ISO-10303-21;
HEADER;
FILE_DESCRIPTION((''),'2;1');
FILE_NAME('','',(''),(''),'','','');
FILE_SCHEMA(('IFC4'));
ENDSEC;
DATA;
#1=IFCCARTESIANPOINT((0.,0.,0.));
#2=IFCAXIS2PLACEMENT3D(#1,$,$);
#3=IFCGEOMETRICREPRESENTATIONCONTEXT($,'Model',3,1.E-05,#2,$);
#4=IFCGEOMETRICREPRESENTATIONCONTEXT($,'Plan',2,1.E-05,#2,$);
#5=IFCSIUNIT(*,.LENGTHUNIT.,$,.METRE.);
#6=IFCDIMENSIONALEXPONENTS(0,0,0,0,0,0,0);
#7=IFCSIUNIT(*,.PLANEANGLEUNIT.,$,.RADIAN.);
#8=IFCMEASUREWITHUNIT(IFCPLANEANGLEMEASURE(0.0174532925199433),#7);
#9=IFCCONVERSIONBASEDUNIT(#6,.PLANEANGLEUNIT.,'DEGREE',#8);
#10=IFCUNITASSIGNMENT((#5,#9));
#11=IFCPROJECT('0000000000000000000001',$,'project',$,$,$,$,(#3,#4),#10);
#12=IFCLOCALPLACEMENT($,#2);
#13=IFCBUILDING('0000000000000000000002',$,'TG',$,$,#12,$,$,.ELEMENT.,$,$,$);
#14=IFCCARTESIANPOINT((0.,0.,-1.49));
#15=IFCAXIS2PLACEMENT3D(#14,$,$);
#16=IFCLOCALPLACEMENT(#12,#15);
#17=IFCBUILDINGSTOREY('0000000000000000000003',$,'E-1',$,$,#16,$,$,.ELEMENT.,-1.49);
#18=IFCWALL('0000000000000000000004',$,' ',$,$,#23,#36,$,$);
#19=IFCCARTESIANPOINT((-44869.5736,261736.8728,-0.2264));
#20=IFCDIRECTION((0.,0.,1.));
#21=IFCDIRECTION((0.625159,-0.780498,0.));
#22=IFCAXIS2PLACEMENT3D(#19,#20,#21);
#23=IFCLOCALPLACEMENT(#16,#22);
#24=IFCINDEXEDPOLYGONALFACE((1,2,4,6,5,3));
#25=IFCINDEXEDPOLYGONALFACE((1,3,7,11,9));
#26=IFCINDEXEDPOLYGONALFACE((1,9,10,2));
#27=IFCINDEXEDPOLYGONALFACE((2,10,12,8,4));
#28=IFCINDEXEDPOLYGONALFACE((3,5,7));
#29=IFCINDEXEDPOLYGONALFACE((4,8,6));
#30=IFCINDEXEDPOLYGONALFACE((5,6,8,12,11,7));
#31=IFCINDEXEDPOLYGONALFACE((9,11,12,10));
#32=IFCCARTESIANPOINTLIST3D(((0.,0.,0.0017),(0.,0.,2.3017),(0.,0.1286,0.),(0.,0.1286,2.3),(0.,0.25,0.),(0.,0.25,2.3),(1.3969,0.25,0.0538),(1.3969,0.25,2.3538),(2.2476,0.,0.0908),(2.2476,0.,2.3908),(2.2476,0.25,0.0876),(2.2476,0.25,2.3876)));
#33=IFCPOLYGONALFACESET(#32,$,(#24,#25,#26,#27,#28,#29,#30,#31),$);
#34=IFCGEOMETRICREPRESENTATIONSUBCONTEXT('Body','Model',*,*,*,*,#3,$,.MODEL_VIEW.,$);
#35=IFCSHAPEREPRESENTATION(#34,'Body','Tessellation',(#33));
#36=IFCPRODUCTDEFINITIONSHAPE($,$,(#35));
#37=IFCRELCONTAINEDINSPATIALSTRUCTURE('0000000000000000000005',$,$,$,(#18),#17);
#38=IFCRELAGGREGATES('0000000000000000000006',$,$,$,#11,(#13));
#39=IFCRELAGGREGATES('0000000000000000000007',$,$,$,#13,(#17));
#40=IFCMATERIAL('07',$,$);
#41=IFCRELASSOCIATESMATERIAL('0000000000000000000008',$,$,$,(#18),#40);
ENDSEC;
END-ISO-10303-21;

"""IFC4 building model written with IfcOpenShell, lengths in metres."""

from ifc_helpers import new_model, entity, si_unit, converted_unit, frame, frame_2d, origin, origin_with_axes, place, context, subcontext, project, spatial, polyline, rectangle, extrude, clip, bounded_halfspace, material, element, save


model = new_model("IFC4")

# Units and contexts
model_context = context("Model", 3, precision=1e-05, world=origin())
plan_context = context("Plan", 2, precision=1e-05, world=origin())
body_context = subcontext(model_context, "Body", "Model", "MODEL_VIEW")
ifc_project = project(units=[si_unit("LENGTHUNIT", "METRE"), converted_unit("PLANEANGLEUNIT", "DEGREE", entity("IfcPlaneAngleMeasure", 0.0174532925199433), si_unit("PLANEANGLEUNIT", "RADIAN"), dimensions=[0, 0, 0, 0, 0, 0, 0])], contexts=[model_context, plan_context])

# Building, storey
building_placement = place(None, origin())
building = spatial("IfcBuilding", under=ifc_project, at=building_placement, Name="TG", CompositionType="ELEMENT")
storey_placement = place(building_placement, frame((0.0, 0.0, -1.49)))
storey = spatial("IfcBuildingStorey", under=building, at=storey_placement, Name="E-1", CompositionType="ELEMENT", Elevation=-1.49)

# Wall
ifc_material_1 = material(Name="07")
wall_1_placement = place(storey_placement, frame((-44869.5736, 261736.8728, -0.2264), z_axis=(0.0, 0.0, 1.0), x_axis=(0.625159, -0.780498, 0.0)))
element("IfcWall", 1, at=wall_1_placement, inside=storey, material=ifc_material_1, Name=" ", context=body_context, shape_type="Clipping", body=[
    clip(clip(clip(clip(extrude(rectangle(XDim=2.2476, YDim=0.25, at=frame_2d((1.1238, 0.125), x_axis=(1.0, 0.0))), origin_with_axes(), (0.0, 0.0, 1.0), 2.3908), bounded_halfspace(frame((1.1784, 0.1257, 0.0468), z_axis=(-0.039625, 0.012849, 0.999132), x_axis=(0.0, 0.999917, -0.012859)), True, origin_with_axes(), polyline([(2.2476, 0.0), (2.2476, 0.25), (1.3969, 0.25), (0.0, 0.1286), (0.0, 0.0), (2.2476, 0.0)]))), bounded_halfspace(frame((0.4656, 0.2095, 0.0179), z_axis=(-0.038513, 0.0, 0.999258), x_axis=(-0.999258, 0.0, -0.038513)), True, origin_with_axes(), polyline([(1.3969, 0.25), (0.0, 0.25), (0.0, 0.1286), (1.3969, 0.25)]))), bounded_halfspace(frame((1.1784, 0.1257, 2.3468), z_axis=(0.039625, -0.012849, -0.999132), x_axis=(-0.999214, 0.0, -0.039628)), True, origin_with_axes(), polyline([(2.2476, 0.25), (1.3969, 0.25), (0.0, 0.1286), (0.0, 0.0), (2.2476, 0.0), (2.2476, 0.25)]))), bounded_halfspace(frame((0.4656, 0.2095, 2.3179), z_axis=(0.038513, 0.0, -0.999258), x_axis=(0.0, -1.0, 0.0)), True, origin_with_axes(), polyline([(0.0, 0.25), (0.0, 0.1286), (1.3969, 0.25), (0.0, 0.25)]))),
])

save(model, "model.ifc")
